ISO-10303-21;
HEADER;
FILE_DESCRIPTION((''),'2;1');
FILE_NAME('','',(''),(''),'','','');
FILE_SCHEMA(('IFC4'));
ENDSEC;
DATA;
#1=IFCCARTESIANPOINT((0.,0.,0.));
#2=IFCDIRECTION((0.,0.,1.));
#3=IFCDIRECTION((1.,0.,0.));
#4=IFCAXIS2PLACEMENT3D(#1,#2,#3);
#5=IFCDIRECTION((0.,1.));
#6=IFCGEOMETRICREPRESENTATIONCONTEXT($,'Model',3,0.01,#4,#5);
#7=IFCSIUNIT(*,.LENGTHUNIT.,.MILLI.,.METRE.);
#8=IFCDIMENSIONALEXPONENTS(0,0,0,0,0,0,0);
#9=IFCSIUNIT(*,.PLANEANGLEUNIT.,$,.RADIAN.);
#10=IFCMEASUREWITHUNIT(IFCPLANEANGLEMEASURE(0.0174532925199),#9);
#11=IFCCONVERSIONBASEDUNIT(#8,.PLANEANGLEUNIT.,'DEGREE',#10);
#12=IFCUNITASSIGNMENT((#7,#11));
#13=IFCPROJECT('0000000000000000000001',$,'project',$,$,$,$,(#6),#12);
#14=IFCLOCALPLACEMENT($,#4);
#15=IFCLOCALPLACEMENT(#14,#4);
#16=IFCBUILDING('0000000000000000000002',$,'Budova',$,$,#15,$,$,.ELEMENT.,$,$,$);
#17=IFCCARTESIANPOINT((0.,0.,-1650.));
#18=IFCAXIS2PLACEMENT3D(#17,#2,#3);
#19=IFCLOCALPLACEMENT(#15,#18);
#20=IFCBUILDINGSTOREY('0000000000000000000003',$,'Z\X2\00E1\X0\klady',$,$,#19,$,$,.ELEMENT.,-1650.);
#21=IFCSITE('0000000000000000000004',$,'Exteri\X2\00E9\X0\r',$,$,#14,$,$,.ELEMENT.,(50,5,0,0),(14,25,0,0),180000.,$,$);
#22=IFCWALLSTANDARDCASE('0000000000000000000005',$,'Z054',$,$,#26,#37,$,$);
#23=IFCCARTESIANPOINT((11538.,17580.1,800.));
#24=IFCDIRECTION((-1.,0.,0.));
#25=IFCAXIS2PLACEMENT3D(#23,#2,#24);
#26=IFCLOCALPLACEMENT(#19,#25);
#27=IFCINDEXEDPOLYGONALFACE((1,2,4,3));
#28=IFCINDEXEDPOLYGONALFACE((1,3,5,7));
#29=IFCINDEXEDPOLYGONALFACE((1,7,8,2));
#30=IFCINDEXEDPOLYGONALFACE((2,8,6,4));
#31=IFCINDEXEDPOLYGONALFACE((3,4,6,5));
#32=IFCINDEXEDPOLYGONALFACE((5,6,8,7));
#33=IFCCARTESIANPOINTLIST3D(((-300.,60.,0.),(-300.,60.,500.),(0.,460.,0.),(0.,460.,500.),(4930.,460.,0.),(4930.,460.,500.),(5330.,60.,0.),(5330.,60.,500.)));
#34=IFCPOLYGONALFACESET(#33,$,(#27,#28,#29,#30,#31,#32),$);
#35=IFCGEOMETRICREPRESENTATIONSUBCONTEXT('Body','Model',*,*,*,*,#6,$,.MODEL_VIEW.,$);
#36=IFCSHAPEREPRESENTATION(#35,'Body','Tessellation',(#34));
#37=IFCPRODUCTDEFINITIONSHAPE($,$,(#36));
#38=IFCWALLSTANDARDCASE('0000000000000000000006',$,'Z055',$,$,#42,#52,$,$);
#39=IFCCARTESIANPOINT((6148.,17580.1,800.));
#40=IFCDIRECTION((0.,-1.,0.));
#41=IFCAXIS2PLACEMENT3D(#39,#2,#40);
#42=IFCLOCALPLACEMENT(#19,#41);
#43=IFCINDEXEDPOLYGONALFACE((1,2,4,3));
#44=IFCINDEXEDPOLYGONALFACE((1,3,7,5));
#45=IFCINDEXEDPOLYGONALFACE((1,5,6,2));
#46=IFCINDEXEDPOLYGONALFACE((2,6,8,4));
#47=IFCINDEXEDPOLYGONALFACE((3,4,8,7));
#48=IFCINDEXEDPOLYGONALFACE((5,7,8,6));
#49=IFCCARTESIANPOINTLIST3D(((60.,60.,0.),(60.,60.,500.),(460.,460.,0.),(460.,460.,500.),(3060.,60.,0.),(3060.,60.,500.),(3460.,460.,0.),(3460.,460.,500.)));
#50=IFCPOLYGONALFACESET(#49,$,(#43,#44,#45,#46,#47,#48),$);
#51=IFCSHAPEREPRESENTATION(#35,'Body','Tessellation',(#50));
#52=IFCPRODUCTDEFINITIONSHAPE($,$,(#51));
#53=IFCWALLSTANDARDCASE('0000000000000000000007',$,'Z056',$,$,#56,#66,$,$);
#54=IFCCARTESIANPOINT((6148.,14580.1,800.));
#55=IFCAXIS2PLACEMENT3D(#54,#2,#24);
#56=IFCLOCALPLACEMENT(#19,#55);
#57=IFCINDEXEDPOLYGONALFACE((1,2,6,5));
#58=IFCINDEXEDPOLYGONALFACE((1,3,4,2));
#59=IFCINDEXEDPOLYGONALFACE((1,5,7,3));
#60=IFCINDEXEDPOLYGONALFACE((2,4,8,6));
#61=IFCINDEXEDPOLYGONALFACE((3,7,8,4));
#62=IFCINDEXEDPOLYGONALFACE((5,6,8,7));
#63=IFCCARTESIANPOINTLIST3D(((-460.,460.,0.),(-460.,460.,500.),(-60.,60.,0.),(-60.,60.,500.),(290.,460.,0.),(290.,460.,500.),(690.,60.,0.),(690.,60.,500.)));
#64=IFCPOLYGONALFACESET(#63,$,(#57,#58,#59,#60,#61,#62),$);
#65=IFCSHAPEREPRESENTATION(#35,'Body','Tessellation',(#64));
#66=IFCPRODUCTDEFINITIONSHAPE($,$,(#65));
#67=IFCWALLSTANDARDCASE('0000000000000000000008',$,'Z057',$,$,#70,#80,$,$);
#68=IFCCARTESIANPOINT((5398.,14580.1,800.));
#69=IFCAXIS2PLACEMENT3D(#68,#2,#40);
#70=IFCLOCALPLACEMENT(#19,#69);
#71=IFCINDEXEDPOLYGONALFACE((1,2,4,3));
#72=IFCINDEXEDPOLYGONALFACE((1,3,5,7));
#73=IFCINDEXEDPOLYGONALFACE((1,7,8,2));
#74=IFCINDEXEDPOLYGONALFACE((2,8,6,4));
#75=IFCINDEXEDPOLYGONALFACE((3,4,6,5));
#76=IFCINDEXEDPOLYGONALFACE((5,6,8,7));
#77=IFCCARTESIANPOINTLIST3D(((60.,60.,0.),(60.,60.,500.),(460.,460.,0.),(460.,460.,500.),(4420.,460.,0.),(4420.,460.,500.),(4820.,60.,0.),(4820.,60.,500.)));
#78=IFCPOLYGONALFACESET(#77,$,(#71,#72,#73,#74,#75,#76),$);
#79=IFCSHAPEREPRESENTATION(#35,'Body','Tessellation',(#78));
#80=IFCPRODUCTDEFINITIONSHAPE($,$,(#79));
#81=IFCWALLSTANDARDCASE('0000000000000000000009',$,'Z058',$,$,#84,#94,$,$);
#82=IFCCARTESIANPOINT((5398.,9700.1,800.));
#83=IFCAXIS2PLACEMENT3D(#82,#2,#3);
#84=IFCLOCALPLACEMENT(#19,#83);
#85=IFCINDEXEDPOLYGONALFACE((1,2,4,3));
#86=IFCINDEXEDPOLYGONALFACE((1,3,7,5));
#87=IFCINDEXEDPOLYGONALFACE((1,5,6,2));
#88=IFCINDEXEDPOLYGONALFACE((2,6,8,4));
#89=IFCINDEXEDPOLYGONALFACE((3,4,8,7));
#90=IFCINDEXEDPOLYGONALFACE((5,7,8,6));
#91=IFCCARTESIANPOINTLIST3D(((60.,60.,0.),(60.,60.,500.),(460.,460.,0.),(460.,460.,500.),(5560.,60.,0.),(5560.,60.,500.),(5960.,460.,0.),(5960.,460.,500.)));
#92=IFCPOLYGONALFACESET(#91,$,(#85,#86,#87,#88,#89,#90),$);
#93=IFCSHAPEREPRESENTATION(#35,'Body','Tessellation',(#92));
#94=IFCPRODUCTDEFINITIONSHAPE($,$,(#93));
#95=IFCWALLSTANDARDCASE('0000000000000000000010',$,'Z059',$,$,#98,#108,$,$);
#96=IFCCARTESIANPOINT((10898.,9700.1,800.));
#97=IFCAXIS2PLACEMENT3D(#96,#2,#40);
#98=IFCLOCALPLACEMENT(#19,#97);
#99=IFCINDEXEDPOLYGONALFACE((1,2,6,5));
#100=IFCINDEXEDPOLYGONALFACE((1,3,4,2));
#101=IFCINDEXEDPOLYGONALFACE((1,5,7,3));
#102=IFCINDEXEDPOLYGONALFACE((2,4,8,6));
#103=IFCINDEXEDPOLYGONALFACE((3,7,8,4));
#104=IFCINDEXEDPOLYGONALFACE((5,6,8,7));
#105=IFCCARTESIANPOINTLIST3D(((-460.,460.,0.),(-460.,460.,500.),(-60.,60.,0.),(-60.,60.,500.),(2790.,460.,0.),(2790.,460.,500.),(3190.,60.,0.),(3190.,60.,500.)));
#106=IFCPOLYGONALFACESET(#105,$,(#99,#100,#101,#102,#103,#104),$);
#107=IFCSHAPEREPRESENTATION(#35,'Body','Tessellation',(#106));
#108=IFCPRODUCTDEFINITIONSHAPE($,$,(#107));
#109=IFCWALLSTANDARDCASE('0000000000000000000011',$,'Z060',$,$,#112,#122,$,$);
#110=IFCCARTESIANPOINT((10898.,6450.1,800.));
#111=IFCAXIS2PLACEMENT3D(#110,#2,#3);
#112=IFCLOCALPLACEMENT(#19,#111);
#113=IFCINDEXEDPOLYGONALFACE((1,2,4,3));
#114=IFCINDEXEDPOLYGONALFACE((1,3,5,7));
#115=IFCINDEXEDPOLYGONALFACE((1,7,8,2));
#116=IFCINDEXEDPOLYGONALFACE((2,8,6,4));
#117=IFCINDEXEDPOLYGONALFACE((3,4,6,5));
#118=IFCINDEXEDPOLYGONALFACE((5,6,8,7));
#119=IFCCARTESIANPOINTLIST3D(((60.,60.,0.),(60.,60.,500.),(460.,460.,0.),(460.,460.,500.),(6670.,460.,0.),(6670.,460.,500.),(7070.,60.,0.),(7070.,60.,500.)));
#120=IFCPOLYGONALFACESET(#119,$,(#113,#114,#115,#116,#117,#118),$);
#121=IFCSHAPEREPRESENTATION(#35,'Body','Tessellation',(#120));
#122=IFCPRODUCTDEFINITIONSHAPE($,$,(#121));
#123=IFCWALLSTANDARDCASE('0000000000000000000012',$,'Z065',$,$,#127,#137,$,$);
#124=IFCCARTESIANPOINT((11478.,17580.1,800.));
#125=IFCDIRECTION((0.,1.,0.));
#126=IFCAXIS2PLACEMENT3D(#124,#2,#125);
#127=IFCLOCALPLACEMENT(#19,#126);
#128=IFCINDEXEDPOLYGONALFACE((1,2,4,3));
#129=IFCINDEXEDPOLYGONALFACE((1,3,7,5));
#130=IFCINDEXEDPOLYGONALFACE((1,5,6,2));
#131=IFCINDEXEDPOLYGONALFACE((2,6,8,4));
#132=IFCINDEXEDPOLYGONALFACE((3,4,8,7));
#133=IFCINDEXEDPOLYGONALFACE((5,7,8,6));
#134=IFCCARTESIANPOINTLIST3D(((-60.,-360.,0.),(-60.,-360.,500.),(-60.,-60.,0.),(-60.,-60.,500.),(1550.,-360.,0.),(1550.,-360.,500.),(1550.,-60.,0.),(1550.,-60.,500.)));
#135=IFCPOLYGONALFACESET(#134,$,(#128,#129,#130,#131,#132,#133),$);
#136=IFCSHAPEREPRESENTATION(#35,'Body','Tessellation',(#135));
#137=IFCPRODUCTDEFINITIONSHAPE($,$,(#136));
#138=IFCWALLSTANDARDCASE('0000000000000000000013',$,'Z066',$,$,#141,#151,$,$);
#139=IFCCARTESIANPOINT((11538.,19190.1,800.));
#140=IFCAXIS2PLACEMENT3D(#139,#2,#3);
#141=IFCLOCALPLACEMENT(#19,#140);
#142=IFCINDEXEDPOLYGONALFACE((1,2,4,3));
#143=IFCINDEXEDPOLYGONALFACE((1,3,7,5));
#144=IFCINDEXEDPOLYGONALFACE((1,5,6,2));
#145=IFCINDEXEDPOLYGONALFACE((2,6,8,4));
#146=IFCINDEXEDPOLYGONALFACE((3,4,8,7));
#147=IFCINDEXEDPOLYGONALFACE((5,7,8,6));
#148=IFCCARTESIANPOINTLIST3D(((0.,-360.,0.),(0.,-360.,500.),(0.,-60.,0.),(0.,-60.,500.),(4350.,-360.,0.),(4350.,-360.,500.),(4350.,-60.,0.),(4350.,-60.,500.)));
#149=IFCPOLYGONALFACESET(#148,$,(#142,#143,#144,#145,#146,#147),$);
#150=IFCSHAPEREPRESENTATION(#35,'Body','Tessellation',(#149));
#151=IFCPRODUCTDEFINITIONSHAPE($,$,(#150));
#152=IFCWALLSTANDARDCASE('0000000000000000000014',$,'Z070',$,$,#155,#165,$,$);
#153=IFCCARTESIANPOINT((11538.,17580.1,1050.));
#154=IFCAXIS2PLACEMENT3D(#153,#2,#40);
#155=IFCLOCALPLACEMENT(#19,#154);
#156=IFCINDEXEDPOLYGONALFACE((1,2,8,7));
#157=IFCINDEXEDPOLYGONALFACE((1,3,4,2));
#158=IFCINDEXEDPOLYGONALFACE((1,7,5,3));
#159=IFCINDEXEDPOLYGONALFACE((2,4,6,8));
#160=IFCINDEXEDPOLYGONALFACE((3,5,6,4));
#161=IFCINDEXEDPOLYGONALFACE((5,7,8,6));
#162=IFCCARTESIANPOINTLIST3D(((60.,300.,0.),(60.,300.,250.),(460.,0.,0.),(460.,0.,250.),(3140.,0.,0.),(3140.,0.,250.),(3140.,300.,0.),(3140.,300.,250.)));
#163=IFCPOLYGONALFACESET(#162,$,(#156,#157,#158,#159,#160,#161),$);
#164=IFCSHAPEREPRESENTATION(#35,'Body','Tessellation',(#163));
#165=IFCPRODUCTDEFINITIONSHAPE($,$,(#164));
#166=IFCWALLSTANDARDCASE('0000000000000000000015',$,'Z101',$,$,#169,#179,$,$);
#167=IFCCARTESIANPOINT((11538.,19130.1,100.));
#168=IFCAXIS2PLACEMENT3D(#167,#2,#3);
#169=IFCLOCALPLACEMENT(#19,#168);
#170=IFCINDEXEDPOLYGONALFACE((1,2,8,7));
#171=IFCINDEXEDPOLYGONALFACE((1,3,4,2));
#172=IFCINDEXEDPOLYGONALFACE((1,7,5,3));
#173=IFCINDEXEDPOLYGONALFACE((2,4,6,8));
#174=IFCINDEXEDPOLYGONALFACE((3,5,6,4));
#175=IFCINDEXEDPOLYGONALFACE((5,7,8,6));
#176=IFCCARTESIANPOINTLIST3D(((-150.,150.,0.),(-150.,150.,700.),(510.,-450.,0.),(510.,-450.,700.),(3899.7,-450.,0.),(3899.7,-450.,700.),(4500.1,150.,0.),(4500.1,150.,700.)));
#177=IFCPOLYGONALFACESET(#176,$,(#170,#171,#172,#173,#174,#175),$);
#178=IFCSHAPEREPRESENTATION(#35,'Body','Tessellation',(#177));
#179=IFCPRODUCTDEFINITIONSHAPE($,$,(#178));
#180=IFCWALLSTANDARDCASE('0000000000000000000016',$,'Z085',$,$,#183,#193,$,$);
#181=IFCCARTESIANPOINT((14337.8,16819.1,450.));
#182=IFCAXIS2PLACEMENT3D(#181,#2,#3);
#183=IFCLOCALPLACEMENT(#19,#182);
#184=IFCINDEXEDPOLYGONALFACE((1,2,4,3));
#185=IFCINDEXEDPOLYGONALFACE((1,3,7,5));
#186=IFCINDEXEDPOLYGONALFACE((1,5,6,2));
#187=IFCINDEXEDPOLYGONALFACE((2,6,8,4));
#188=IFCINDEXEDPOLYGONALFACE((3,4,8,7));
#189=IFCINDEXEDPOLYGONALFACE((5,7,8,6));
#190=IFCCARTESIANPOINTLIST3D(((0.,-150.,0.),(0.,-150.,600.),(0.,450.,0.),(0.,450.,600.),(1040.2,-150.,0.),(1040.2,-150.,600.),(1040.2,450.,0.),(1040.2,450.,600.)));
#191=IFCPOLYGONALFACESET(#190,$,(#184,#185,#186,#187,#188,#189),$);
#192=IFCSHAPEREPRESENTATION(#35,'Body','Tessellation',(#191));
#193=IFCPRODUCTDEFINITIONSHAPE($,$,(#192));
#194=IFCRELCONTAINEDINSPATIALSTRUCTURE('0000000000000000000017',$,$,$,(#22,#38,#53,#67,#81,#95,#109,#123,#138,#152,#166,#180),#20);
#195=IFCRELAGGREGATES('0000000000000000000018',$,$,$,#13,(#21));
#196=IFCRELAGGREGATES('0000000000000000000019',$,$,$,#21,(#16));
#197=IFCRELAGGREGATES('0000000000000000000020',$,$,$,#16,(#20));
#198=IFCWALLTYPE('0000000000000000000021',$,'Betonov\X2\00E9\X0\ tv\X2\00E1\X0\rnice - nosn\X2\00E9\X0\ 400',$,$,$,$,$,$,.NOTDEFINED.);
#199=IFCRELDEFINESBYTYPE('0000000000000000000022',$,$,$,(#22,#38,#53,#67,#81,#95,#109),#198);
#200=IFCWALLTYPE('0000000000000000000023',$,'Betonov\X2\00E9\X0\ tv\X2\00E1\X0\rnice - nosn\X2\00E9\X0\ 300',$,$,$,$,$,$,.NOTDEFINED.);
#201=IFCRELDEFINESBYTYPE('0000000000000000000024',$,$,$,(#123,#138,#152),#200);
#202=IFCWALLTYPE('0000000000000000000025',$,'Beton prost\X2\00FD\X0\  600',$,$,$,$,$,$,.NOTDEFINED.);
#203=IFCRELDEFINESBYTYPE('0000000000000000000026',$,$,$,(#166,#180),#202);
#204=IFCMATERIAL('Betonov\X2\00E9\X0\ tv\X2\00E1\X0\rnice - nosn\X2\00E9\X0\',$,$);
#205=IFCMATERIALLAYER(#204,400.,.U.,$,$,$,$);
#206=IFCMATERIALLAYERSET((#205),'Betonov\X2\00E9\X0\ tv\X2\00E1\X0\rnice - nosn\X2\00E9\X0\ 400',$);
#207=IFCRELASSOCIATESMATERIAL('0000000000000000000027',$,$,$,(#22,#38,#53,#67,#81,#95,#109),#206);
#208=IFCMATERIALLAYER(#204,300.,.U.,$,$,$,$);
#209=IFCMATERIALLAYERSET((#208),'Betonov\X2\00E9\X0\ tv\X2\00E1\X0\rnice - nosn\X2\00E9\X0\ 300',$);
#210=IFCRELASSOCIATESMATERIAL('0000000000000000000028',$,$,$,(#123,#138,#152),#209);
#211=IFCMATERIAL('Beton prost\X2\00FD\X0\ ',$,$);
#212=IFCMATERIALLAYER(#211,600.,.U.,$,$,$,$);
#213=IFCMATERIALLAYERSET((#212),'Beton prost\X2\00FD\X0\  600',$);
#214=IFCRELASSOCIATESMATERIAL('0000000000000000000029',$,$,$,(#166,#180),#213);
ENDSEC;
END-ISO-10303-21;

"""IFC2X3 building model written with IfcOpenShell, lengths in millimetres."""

from ifc_helpers import new_model, entity, si_unit, converted_unit, direction, frame, origin_with_axes, place, context, subcontext, project, spatial, polyline, outline, extrude, material, layer, layer_set, layer_usage, type_object, element, save


model = new_model("IFC2X3")

# Units and contexts
model_context = context("Model", 3, precision=0.01, world=origin_with_axes(), true_north=direction((0.0, 1.0)))
body_context = subcontext(model_context, "Body", "Model", "MODEL_VIEW")
ifc_project = project(units=[si_unit("LENGTHUNIT", "METRE", prefix="MILLI"), converted_unit("PLANEANGLEUNIT", "DEGREE", entity("IfcPlaneAngleMeasure", 0.0174532925199), si_unit("PLANEANGLEUNIT", "RADIAN"), dimensions=[0, 0, 0, 0, 0, 0, 0])], contexts=[model_context])

# Site, building, storey
site_placement = place(None, origin_with_axes())
site = spatial("IfcSite", under=ifc_project, at=site_placement, Name="Exteriér", CompositionType="ELEMENT", RefLatitude=(50, 5, 0, 0), RefLongitude=(14, 25, 0, 0), RefElevation=180000.0)
building_placement = place(site_placement, origin_with_axes())
building = spatial("IfcBuilding", under=site, at=building_placement, Name="Budova", CompositionType="ELEMENT")
storey_placement = place(building_placement, frame((0.0, 0.0, -1650.0), z_axis=(0.0, 0.0, 1.0), x_axis=(1.0, 0.0, 0.0)))
storey = spatial("IfcBuildingStorey", under=building, at=storey_placement, Name="Základy", CompositionType="ELEMENT", Elevation=-1650.0)

# Shared definitions
ifc_material_1 = material(Name="Beton prostý ")

# Walls
ifc_material_2 = material(Name="Betonové tvárnice - nosné")
ifc_layer_1 = layer(ifc_material_2, 400.0, ventilated="UNKNOWN")
ifc_layer_set_1 = layer_set([ifc_layer_1], Name="Betonové tvárnice - nosné 400")
ifc_layer_usage_1 = layer_usage(ifc_layer_set_1, "AXIS2", "POSITIVE", 60.0)
wall_type_1 = type_object("IfcWallType", Name="Betonové tvárnice - nosné 400", PredefinedType="NOTDEFINED")
wall_1_placement = place(storey_placement, frame((11538.0, 17580.1, 800.0), z_axis=(0.0, 0.0, 1.0), x_axis=(-1.0, 0.0, 0.0)))
element("IfcWallStandardCase", 1, at=wall_1_placement, inside=storey, type_object=wall_type_1, material=ifc_layer_usage_1, Name="Z054", context=body_context, shape_type="SweptSolid", body=[
    extrude(outline(polyline([(-300.0, 60.0), (5330.0, 60.0), (4930.0, 460.0), (0.0, 460.0), (-300.0, 60.0)])), origin_with_axes(), (0.0, 0.0, 1.0), 500.0),
])
ifc_layer_usage_2 = layer_usage(ifc_layer_set_1, "AXIS2", "POSITIVE", 60.0)
wall_2_placement = place(storey_placement, frame((6148.0, 17580.1, 800.0), z_axis=(0.0, 0.0, 1.0), x_axis=(0.0, -1.0, 0.0)))
element("IfcWallStandardCase", 2, at=wall_2_placement, inside=storey, type_object=wall_type_1, material=ifc_layer_usage_2, Name="Z055", context=body_context, shape_type="SweptSolid", body=[
    extrude(outline(polyline([(60.0, 60.0), (3060.0, 60.0), (3460.0, 460.0), (460.0, 460.0), (60.0, 60.0)])), origin_with_axes(), (0.0, 0.0, 1.0), 500.0),
])
ifc_layer_usage_3 = layer_usage(ifc_layer_set_1, "AXIS2", "POSITIVE", 60.0)
wall_3_placement = place(storey_placement, frame((6148.0, 14580.1, 800.0), z_axis=(0.0, 0.0, 1.0), x_axis=(-1.0, 0.0, 0.0)))
element("IfcWallStandardCase", 3, at=wall_3_placement, inside=storey, type_object=wall_type_1, material=ifc_layer_usage_3, Name="Z056", context=body_context, shape_type="SweptSolid", body=[
    extrude(outline(polyline([(-60.0, 60.0), (690.0, 60.0), (290.0, 460.0), (-460.0, 460.0), (-60.0, 60.0)])), origin_with_axes(), (0.0, 0.0, 1.0), 500.0),
])
ifc_layer_usage_4 = layer_usage(ifc_layer_set_1, "AXIS2", "POSITIVE", 60.0)
wall_4_placement = place(storey_placement, frame((5398.0, 14580.1, 800.0), z_axis=(0.0, 0.0, 1.0), x_axis=(0.0, -1.0, 0.0)))
element("IfcWallStandardCase", 4, at=wall_4_placement, inside=storey, type_object=wall_type_1, material=ifc_layer_usage_4, Name="Z057", context=body_context, shape_type="SweptSolid", body=[
    extrude(outline(polyline([(60.0, 60.0), (4820.0, 60.0), (4420.0, 460.0), (460.0, 460.0), (60.0, 60.0)])), origin_with_axes(), (0.0, 0.0, 1.0), 500.0),
])
ifc_layer_usage_5 = layer_usage(ifc_layer_set_1, "AXIS2", "POSITIVE", 60.0)
wall_5_placement = place(storey_placement, frame((5398.0, 9700.1, 800.0), z_axis=(0.0, 0.0, 1.0), x_axis=(1.0, 0.0, 0.0)))
element("IfcWallStandardCase", 5, at=wall_5_placement, inside=storey, type_object=wall_type_1, material=ifc_layer_usage_5, Name="Z058", context=body_context, shape_type="SweptSolid", body=[
    extrude(outline(polyline([(60.0, 60.0), (5560.0, 60.0), (5960.0, 460.0), (460.0, 460.0), (60.0, 60.0)])), origin_with_axes(), (0.0, 0.0, 1.0), 500.0),
])
ifc_layer_usage_6 = layer_usage(ifc_layer_set_1, "AXIS2", "POSITIVE", 60.0)
wall_6_placement = place(storey_placement, frame((10898.0, 9700.1, 800.0), z_axis=(0.0, 0.0, 1.0), x_axis=(0.0, -1.0, 0.0)))
element("IfcWallStandardCase", 6, at=wall_6_placement, inside=storey, type_object=wall_type_1, material=ifc_layer_usage_6, Name="Z059", context=body_context, shape_type="SweptSolid", body=[
    extrude(outline(polyline([(-60.0, 60.0), (3190.0, 60.0), (2790.0, 460.0), (-460.0, 460.0), (-60.0, 60.0)])), origin_with_axes(), (0.0, 0.0, 1.0), 500.0),
])
ifc_layer_usage_7 = layer_usage(ifc_layer_set_1, "AXIS2", "POSITIVE", 60.0)
wall_7_placement = place(storey_placement, frame((10898.0, 6450.1, 800.0), z_axis=(0.0, 0.0, 1.0), x_axis=(1.0, 0.0, 0.0)))
element("IfcWallStandardCase", 7, at=wall_7_placement, inside=storey, type_object=wall_type_1, material=ifc_layer_usage_7, Name="Z060", context=body_context, shape_type="SweptSolid", body=[
    extrude(outline(polyline([(60.0, 60.0), (7070.0, 60.0), (6670.0, 460.0), (460.0, 460.0), (60.0, 60.0)])), origin_with_axes(), (0.0, 0.0, 1.0), 500.0),
])
ifc_layer_2 = layer(ifc_material_2, 300.0, ventilated="UNKNOWN")
ifc_layer_set_2 = layer_set([ifc_layer_2], Name="Betonové tvárnice - nosné 300")
ifc_layer_usage_8 = layer_usage(ifc_layer_set_2, "AXIS2", "POSITIVE", -360.0)
wall_type_2 = type_object("IfcWallType", Name="Betonové tvárnice - nosné 300", PredefinedType="NOTDEFINED")
wall_8_placement = place(storey_placement, frame((11478.0, 17580.1, 800.0), z_axis=(0.0, 0.0, 1.0), x_axis=(0.0, 1.0, 0.0)))
element("IfcWallStandardCase", 8, at=wall_8_placement, inside=storey, type_object=wall_type_2, material=ifc_layer_usage_8, Name="Z065", context=body_context, shape_type="SweptSolid", body=[
    extrude(outline(polyline([(-60.0, -360.0), (1550.0, -360.0), (1550.0, -60.0), (-60.0, -60.0), (-60.0, -360.0)])), origin_with_axes(), (0.0, 0.0, 1.0), 500.0),
])
ifc_layer_usage_9 = layer_usage(ifc_layer_set_2, "AXIS2", "POSITIVE", -360.0)
wall_9_placement = place(storey_placement, frame((11538.0, 19190.1, 800.0), z_axis=(0.0, 0.0, 1.0), x_axis=(1.0, 0.0, 0.0)))
element("IfcWallStandardCase", 9, at=wall_9_placement, inside=storey, type_object=wall_type_2, material=ifc_layer_usage_9, Name="Z066", context=body_context, shape_type="SweptSolid", body=[
    extrude(outline(polyline([(0.0, -360.0), (4350.0, -360.0), (4350.0, -60.0), (0.0, -60.0), (0.0, -360.0)])), origin_with_axes(), (0.0, 0.0, 1.0), 500.0),
])
ifc_layer_usage_10 = layer_usage(ifc_layer_set_2, "AXIS2", "POSITIVE", 0.0)
wall_10_placement = place(storey_placement, frame((11538.0, 17580.1, 1050.0), z_axis=(0.0, 0.0, 1.0), x_axis=(0.0, -1.0, 0.0)))
element("IfcWallStandardCase", 10, at=wall_10_placement, inside=storey, type_object=wall_type_2, material=ifc_layer_usage_10, Name="Z070", context=body_context, shape_type="SweptSolid", body=[
    extrude(outline(polyline([(460.0, 0.0), (3140.0, 0.0), (3140.0, 300.0), (60.0, 300.0), (460.0, 0.0)])), origin_with_axes(), (0.0, 0.0, 1.0), 250.0),
])
ifc_layer_3 = layer(ifc_material_1, 600.0, ventilated="UNKNOWN")
ifc_layer_set_3 = layer_set([ifc_layer_3], Name="Beton prostý  600")
ifc_layer_usage_11 = layer_usage(ifc_layer_set_3, "AXIS2", "POSITIVE", -450.0)
wall_type_3 = type_object("IfcWallType", Name="Beton prostý  600", PredefinedType="NOTDEFINED")
wall_11_placement = place(storey_placement, frame((11538.0, 19130.1, 100.0), z_axis=(0.0, 0.0, 1.0), x_axis=(1.0, 0.0, 0.0)))
element("IfcWallStandardCase", 11, at=wall_11_placement, inside=storey, type_object=wall_type_3, material=ifc_layer_usage_11, Name="Z101", context=body_context, shape_type="SweptSolid", body=[
    extrude(outline(polyline([(510.0, -450.0), (3899.7, -450.0), (4500.1, 150.0), (-150.0, 150.0), (510.0, -450.0)])), origin_with_axes(), (0.0, 0.0, 1.0), 700.0),
])
ifc_layer_usage_12 = layer_usage(ifc_layer_set_3, "AXIS2", "POSITIVE", -150.0)
wall_12_placement = place(storey_placement, frame((14337.8, 16819.1, 450.0), z_axis=(0.0, 0.0, 1.0), x_axis=(1.0, 0.0, 0.0)))
element("IfcWallStandardCase", 12, at=wall_12_placement, inside=storey, type_object=wall_type_3, material=ifc_layer_usage_12, Name="Z085", context=body_context, shape_type="SweptSolid", body=[
    extrude(outline(polyline([(0.0, -150.0), (1040.2, -150.0), (1040.2, 450.0), (0.0, 450.0), (0.0, -150.0)])), origin_with_axes(), (0.0, 0.0, 1.0), 600.0),
])

save(model, "model.ifc")
